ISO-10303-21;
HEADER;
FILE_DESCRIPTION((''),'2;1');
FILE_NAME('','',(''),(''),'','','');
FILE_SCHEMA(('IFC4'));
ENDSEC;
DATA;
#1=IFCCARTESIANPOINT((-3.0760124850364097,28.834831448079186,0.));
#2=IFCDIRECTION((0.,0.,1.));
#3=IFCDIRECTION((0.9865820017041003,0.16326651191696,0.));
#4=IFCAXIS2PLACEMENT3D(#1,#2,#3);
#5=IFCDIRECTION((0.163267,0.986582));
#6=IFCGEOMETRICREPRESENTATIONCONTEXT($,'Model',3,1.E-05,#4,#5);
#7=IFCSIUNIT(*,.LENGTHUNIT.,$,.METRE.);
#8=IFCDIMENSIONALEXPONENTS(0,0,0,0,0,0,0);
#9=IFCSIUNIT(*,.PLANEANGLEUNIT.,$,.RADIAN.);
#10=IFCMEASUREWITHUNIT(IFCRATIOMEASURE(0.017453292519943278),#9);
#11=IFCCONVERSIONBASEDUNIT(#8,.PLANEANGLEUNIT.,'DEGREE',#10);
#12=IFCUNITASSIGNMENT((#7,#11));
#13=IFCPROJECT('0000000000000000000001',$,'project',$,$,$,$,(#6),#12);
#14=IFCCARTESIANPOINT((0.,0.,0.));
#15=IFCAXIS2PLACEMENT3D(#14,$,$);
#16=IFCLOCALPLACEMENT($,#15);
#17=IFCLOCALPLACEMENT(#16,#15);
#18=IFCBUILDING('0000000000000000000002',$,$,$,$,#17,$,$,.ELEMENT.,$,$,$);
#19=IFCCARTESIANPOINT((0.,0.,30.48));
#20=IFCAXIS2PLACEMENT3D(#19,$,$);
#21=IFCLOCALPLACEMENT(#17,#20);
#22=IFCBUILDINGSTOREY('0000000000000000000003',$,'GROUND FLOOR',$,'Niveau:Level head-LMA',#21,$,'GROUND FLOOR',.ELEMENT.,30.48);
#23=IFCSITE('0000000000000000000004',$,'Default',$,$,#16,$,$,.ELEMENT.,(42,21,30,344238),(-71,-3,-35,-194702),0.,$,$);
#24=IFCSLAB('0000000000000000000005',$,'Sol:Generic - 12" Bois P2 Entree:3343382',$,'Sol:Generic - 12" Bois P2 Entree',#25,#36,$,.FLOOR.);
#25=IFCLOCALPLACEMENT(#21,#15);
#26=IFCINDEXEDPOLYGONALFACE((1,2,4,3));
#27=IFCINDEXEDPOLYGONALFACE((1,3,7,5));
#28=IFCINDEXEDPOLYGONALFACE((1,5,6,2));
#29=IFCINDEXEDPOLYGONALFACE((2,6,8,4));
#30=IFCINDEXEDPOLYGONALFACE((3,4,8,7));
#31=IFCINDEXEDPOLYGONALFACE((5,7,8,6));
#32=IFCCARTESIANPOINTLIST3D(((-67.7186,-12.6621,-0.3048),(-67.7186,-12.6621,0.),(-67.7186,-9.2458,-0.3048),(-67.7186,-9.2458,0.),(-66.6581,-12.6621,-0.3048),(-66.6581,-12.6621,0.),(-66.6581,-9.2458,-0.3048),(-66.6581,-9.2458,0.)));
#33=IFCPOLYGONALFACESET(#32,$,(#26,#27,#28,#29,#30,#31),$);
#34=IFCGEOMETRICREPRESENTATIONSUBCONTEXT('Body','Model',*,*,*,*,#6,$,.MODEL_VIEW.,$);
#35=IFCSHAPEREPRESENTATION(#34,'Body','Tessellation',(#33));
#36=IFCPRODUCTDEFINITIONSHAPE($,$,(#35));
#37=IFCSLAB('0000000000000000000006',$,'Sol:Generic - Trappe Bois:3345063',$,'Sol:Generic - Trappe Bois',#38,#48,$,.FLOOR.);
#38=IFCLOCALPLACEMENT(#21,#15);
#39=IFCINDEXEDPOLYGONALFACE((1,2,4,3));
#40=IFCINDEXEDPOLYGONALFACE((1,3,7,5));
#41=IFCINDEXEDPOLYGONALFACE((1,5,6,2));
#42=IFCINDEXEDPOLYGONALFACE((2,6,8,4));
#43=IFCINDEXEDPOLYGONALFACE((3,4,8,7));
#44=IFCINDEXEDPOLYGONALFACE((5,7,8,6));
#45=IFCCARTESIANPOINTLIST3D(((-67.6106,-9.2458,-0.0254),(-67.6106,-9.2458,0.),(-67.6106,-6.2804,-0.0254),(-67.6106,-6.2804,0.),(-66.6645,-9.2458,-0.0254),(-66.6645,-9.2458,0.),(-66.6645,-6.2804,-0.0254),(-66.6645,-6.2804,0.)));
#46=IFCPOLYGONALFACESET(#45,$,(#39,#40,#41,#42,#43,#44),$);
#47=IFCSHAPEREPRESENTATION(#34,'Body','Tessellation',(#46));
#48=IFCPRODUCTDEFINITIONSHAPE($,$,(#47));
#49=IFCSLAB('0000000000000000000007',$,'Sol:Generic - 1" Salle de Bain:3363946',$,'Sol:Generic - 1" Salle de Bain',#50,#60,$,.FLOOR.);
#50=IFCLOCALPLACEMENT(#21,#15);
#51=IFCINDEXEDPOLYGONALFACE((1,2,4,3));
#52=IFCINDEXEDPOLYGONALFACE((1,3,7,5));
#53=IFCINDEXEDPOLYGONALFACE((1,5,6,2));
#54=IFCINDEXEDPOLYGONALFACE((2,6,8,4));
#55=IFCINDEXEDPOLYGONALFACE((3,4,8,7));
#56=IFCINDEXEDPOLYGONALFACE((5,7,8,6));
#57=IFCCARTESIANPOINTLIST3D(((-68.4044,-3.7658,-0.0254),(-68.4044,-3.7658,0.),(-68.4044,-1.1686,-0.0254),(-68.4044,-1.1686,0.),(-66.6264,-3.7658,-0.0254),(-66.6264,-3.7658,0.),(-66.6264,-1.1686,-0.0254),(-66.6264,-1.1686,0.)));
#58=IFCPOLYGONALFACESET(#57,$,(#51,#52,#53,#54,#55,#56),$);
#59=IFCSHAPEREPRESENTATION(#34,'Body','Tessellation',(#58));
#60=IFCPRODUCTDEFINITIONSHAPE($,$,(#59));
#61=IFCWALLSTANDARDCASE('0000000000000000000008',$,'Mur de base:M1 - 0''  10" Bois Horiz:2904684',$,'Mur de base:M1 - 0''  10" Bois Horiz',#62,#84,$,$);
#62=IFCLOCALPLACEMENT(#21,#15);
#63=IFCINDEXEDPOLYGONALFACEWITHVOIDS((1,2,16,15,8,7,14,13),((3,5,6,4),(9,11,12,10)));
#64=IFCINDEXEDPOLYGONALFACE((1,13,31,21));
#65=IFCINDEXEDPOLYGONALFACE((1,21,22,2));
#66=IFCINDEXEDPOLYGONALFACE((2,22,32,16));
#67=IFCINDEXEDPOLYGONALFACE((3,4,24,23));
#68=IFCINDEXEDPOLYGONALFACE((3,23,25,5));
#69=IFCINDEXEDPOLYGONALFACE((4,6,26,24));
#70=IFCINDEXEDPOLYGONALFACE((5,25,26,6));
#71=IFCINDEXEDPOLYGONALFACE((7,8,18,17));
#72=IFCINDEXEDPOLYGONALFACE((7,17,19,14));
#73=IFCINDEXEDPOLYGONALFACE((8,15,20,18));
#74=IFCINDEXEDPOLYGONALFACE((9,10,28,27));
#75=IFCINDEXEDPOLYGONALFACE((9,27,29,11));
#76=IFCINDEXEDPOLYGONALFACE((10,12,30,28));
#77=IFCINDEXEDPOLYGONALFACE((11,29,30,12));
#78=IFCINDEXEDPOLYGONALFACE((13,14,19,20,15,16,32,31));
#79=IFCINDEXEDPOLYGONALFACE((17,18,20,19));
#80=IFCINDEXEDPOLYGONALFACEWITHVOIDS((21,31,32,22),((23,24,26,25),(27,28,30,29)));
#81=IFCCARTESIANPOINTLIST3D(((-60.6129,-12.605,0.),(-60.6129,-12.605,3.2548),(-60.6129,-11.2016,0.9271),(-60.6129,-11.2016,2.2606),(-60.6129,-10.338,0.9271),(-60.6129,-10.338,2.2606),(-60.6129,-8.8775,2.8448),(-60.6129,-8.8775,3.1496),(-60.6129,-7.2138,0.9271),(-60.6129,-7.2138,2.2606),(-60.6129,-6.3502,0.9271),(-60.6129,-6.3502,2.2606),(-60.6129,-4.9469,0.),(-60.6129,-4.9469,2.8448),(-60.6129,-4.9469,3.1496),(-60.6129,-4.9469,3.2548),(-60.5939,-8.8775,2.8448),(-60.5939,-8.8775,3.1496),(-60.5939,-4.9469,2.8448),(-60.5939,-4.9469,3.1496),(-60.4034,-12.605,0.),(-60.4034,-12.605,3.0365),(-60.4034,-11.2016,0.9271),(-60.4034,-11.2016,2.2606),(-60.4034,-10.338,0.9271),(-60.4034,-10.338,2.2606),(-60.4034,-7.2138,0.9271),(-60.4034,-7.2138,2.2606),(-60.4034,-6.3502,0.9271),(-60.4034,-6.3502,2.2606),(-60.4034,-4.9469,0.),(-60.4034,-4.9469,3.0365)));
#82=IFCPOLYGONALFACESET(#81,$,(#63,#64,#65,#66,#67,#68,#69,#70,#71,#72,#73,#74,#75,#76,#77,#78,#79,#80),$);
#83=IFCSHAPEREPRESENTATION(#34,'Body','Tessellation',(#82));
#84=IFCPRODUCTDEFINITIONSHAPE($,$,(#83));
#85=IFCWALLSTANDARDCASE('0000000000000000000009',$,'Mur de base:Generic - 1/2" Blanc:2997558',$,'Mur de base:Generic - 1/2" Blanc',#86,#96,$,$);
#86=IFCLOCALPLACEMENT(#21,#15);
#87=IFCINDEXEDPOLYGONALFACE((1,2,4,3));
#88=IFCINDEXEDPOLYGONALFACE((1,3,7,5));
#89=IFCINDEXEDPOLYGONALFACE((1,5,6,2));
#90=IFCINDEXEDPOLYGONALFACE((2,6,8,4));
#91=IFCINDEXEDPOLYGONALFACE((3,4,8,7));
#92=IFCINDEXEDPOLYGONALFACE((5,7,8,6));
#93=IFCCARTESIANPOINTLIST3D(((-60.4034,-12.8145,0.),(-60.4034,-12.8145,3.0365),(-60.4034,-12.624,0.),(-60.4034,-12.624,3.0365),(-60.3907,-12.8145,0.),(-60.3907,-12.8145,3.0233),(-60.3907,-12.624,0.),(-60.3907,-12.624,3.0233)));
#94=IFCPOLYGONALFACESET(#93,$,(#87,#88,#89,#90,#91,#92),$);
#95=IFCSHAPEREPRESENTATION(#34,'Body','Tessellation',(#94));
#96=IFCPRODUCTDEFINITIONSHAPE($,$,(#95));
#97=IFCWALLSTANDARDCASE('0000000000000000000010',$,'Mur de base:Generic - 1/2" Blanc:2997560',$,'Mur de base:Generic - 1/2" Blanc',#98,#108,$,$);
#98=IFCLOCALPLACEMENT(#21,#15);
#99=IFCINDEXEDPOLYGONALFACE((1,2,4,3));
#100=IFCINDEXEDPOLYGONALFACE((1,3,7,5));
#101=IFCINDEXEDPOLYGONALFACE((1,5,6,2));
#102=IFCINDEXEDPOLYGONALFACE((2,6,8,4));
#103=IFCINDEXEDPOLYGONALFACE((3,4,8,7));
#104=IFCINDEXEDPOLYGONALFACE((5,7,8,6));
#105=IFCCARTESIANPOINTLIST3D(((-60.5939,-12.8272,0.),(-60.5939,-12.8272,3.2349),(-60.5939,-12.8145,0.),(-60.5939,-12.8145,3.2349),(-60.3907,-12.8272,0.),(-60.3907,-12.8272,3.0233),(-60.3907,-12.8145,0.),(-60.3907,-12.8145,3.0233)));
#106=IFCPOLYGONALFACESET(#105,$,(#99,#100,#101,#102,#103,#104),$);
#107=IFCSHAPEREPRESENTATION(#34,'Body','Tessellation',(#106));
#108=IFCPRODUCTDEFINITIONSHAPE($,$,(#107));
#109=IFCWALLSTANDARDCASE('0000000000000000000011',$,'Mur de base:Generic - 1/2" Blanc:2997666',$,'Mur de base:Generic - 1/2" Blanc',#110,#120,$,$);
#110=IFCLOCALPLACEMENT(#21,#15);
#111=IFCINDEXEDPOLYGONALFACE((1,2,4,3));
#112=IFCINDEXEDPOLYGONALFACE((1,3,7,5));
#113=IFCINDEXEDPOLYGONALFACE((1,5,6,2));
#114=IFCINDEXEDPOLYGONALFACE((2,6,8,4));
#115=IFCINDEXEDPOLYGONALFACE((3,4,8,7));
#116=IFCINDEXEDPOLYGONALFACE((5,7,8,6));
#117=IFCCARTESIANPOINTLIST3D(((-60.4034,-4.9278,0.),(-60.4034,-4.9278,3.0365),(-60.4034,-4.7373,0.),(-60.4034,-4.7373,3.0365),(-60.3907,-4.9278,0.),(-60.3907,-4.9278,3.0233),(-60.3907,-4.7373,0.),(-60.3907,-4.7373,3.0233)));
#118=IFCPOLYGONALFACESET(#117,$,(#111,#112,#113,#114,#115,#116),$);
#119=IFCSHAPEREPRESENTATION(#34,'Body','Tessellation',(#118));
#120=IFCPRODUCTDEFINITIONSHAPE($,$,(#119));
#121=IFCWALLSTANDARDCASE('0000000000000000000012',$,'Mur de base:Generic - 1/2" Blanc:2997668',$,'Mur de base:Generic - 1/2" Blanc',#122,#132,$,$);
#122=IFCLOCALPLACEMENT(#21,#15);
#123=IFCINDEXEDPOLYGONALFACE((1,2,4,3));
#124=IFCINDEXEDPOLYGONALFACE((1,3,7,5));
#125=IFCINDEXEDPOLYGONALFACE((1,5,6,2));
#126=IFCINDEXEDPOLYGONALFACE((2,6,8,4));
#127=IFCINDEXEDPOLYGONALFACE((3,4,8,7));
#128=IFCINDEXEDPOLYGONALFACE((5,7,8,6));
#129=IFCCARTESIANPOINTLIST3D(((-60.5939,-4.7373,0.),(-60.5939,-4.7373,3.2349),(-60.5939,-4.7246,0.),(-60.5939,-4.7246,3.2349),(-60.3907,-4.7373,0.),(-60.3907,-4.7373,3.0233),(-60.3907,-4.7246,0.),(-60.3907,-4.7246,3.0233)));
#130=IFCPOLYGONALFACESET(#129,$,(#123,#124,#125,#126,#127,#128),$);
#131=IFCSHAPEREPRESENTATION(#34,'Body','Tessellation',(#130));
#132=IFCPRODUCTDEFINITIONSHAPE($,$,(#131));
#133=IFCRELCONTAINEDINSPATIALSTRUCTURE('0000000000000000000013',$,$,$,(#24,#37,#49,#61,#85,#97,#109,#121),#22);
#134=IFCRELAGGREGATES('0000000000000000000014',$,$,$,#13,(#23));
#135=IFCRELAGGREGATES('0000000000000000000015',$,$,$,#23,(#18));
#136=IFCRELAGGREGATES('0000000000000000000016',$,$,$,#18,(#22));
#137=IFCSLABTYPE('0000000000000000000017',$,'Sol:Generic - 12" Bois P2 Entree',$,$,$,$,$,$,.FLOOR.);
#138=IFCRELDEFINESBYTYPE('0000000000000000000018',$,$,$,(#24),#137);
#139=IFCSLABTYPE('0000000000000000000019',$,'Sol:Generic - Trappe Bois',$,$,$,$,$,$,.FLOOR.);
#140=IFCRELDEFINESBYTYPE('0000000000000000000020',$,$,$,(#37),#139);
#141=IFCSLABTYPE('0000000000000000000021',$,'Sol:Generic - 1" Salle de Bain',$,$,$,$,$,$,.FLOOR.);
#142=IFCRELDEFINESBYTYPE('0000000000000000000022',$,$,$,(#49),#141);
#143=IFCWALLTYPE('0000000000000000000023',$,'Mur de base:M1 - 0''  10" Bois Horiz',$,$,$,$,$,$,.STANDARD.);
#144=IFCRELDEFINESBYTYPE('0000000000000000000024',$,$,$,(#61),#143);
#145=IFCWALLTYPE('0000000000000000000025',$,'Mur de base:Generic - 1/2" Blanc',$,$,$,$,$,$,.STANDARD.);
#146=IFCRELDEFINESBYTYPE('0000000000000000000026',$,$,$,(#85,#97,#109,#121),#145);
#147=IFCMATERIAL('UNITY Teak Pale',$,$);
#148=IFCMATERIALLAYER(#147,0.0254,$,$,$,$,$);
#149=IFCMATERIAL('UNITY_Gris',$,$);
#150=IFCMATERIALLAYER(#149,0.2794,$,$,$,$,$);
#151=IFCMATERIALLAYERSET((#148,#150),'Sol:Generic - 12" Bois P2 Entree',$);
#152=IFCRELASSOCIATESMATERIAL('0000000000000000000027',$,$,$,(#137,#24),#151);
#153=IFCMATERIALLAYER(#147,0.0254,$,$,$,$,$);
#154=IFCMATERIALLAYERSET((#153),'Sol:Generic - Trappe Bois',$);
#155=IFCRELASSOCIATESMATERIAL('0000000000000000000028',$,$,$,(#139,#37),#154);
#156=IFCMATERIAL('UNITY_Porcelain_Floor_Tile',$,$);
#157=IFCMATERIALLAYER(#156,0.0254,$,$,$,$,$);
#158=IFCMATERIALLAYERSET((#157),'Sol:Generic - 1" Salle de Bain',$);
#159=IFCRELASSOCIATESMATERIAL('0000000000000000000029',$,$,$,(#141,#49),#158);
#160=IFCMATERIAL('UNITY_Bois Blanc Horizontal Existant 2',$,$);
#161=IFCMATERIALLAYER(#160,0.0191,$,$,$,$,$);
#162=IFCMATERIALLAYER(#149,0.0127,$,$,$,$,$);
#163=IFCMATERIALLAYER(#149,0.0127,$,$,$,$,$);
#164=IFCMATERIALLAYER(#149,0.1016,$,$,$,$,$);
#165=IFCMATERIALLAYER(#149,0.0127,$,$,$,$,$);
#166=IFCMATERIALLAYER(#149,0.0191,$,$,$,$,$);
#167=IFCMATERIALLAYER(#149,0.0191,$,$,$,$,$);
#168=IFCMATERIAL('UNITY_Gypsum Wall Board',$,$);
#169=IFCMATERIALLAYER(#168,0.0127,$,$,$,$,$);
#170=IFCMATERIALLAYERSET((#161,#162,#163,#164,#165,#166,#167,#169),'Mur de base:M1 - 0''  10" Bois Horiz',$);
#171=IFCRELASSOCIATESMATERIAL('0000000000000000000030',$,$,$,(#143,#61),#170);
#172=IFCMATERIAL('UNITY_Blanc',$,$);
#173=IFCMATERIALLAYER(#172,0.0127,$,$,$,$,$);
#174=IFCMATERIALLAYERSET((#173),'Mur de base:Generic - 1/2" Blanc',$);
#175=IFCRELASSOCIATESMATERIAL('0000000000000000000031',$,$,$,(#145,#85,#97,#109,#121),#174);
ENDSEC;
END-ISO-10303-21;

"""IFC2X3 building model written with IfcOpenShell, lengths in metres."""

from ifc_helpers import new_model, entity, si_unit, converted_unit, direction, frame, frame_2d, origin, place, context, subcontext, project, spatial, polyline, rectangle, extrude, clip, bounded_halfspace, material, layer, layer_set, layer_usage, type_object, element, save


model = new_model("IFC2X3")

# Units and contexts
model_context = context("Model", 3, precision=1e-05, world=frame((-3.0760124850364097, 28.834831448079186, 0.0), z_axis=(0.0, 0.0, 1.0), x_axis=(0.9865820017041003, 0.16326651191696, 0.0)), true_north=direction((0.163267, 0.986582)))
body_context = subcontext(model_context, "Body", "Model", "MODEL_VIEW")
ifc_project = project(units=[si_unit("LENGTHUNIT", "METRE"), converted_unit("PLANEANGLEUNIT", "DEGREE", entity("IfcRatioMeasure", 0.017453292519943278), si_unit("PLANEANGLEUNIT", "RADIAN"), dimensions=[0, 0, 0, 0, 0, 0, 0])], contexts=[model_context])

# Site, building, storey
site_placement = place(None, origin())
site = spatial("IfcSite", under=ifc_project, at=site_placement, Name="Default", CompositionType="ELEMENT", RefLatitude=(42, 21, 30, 344238), RefLongitude=(-71, -3, -35, -194702), RefElevation=0.0)
building_placement = place(site_placement, origin())
building = spatial("IfcBuilding", under=site, at=building_placement, CompositionType="ELEMENT")
storey_placement = place(building_placement, frame((0.0, 0.0, 30.48)))
storey = spatial("IfcBuildingStorey", under=building, at=storey_placement, Name="GROUND FLOOR", ObjectType="Niveau:Level head-LMA", LongName="GROUND FLOOR", CompositionType="ELEMENT", Elevation=30.48)

# Slabs
ifc_material_1 = material(Name="UNITY_Gris")
ifc_material_2 = material(Name="UNITY Teak Pale")
ifc_layer_1 = layer(ifc_material_2, 0.0254)
ifc_layer_2 = layer(ifc_material_1, 0.2794)
ifc_layer_set_1 = layer_set([ifc_layer_1, ifc_layer_2], Name="Sol:Generic - 12\" Bois P2 Entree")
ifc_layer_usage_1 = layer_usage(ifc_layer_set_1, "AXIS3", "POSITIVE", 0.0)
slab_type_1 = type_object("IfcSlabType", Name="Sol:Generic - 12\" Bois P2 Entree", PredefinedType="FLOOR", material=ifc_layer_set_1)
slab_1_placement = place(storey_placement, origin())
element("IfcSlab", 1, at=slab_1_placement, inside=storey, type_object=slab_type_1, material=ifc_layer_usage_1, Name="Sol:Generic - 12\" Bois P2 Entree:3343382", ObjectType="Sol:Generic - 12\" Bois P2 Entree", PredefinedType="FLOOR", context=body_context, shape_type="SweptSolid", body=[
    extrude(rectangle(XDim=3.4163, YDim=1.0605, at=frame_2d((0.0, 0.0), x_axis=(1.0, 0.0))), frame((-67.1884, -10.954, 0.0), z_axis=(0.0, 0.0, -1.0), x_axis=(0.0, 1.0, 0.0)), (0.0, 0.0, 1.0), 0.3048),
])
ifc_layer_3 = layer(ifc_material_2, 0.0254)
ifc_layer_set_2 = layer_set([ifc_layer_3], Name="Sol:Generic - Trappe Bois")
ifc_layer_usage_2 = layer_usage(ifc_layer_set_2, "AXIS3", "POSITIVE", 0.0)
slab_type_2 = type_object("IfcSlabType", Name="Sol:Generic - Trappe Bois", PredefinedType="FLOOR", material=ifc_layer_set_2)
slab_2_placement = place(storey_placement, origin())
element("IfcSlab", 2, at=slab_2_placement, inside=storey, type_object=slab_type_2, material=ifc_layer_usage_2, Name="Sol:Generic - Trappe Bois:3345063", ObjectType="Sol:Generic - Trappe Bois", PredefinedType="FLOOR", context=body_context, shape_type="SweptSolid", body=[
    extrude(rectangle(XDim=2.9654, YDim=0.9462, at=frame_2d((0.0, 0.0), x_axis=(1.0, 0.0))), frame((-67.1376, -7.7631, 0.0), z_axis=(0.0, 0.0, -1.0), x_axis=(0.0, 1.0, 0.0)), (0.0, 0.0, 1.0), 0.0254),
])
ifc_material_3 = material(Name="UNITY_Porcelain_Floor_Tile")
ifc_layer_4 = layer(ifc_material_3, 0.0254)
ifc_layer_set_3 = layer_set([ifc_layer_4], Name="Sol:Generic - 1\" Salle de Bain")
ifc_layer_usage_3 = layer_usage(ifc_layer_set_3, "AXIS3", "POSITIVE", 0.0)
slab_type_3 = type_object("IfcSlabType", Name="Sol:Generic - 1\" Salle de Bain", PredefinedType="FLOOR", material=ifc_layer_set_3)
slab_3_placement = place(storey_placement, origin())
element("IfcSlab", 3, at=slab_3_placement, inside=storey, type_object=slab_type_3, material=ifc_layer_usage_3, Name="Sol:Generic - 1\" Salle de Bain:3363946", ObjectType="Sol:Generic - 1\" Salle de Bain", PredefinedType="FLOOR", context=body_context, shape_type="SweptSolid", body=[
    extrude(rectangle(XDim=2.5971, YDim=1.778, at=frame_2d((0.0, 0.0), x_axis=(1.0, 0.0))), frame((-67.5154, -2.4672, 0.0), z_axis=(0.0, 0.0, -1.0), x_axis=(0.0, 1.0, 0.0)), (0.0, 0.0, 1.0), 0.0254),
])

# Wall, openings
ifc_material_4 = material(Name="UNITY_Bois Blanc Horizontal Existant 2")
ifc_layer_5 = layer(ifc_material_4, 0.0191)
ifc_layer_6 = layer(ifc_material_1, 0.0127)
ifc_layer_7 = layer(ifc_material_1, 0.0127)
ifc_layer_8 = layer(ifc_material_1, 0.1016)
ifc_layer_9 = layer(ifc_material_1, 0.0127)
ifc_layer_10 = layer(ifc_material_1, 0.0191)
ifc_layer_11 = layer(ifc_material_1, 0.0191)
ifc_material_5 = material(Name="UNITY_Gypsum Wall Board")
ifc_layer_12 = layer(ifc_material_5, 0.0127)
ifc_layer_set_4 = layer_set([ifc_layer_5, ifc_layer_6, ifc_layer_7, ifc_layer_8, ifc_layer_9, ifc_layer_10, ifc_layer_11, ifc_layer_12], Name="Mur de base:M1 - 0'  10\" Bois Horiz")
ifc_layer_usage_4 = layer_usage(ifc_layer_set_4, "AXIS2", "NEGATIVE", 0.1048)
wall_type_1 = type_object("IfcWallType", Name="Mur de base:M1 - 0'  10\" Bois Horiz", PredefinedType="STANDARD", material=ifc_layer_set_4)
wall_1_placement = place(storey_placement, frame((-60.5082, -4.9469, 0.0), z_axis=(0.0, 0.0, 1.0), x_axis=(0.0, -1.0, 0.0)))
wall_1 = element("IfcWallStandardCase", 4, at=wall_1_placement, inside=storey, type_object=wall_type_1, material=ifc_layer_usage_4, Name="Mur de base:M1 - 0'  10\" Bois Horiz:2904684", ObjectType="Mur de base:M1 - 0'  10\" Bois Horiz", context=body_context, shape_type="Clipping", body=[
    clip(extrude(rectangle(XDim=7.6581, YDim=0.2096, at=frame_2d((3.8291, 0.0), x_axis=(-1.0, 0.0))), origin(), (0.0, 0.0, 1.0), 3.2548), bounded_halfspace(frame((0.0, -0.1048, 3.2548), z_axis=(0.0, 0.721387, 0.692532), x_axis=(-1.0, 0.0, 0.0)), False, frame((0.0, -0.1048, 3.2548)), polyline([(0.0, 0.0), (7.6581, 0.0), (7.6581, 0.2095), (0.0, 0.2096), (0.0, 0.0)]))),
])
opening_1_placement = place(storey_placement, frame((-60.5082, -4.9469, 0.0), z_axis=(0.0, 0.0, 1.0), x_axis=(0.0, -1.0, 0.0)))
element("IfcOpeningElement", 5, at=opening_1_placement, cuts=wall_1, ObjectType="Opening", context=body_context, shape_type="SweptSolid", body=[
    extrude(rectangle(XDim=0.019, YDim=3.9306, at=frame_2d((0.0, 0.0), x_axis=(1.0, 0.0))), frame((1.9653, -0.0953, 2.8448), z_axis=(0.0, 0.0, 1.0), x_axis=(0.0, 1.0, 0.0)), (0.0, 0.0, 1.0), 0.3048),
])
opening_2_placement = place(wall_1_placement, frame((-4.9469, 60.5082, 0.0), z_axis=(0.0, 0.0, 1.0), x_axis=(0.0, 1.0, 0.0)))
element("IfcOpeningElement", 6, at=opening_2_placement, cuts=wall_1, ObjectType="Opening", context=body_context, shape_type="SweptSolid", body=[
    extrude(rectangle(XDim=1.3335, YDim=0.8636, at=frame_2d((0.0, 0.0), x_axis=(1.0, 0.0))), frame((-62.1369, -6.782, 1.5938), z_axis=(1.0, 0.0, 0.0), x_axis=(0.0, 0.0, 1.0)), (0.0, 0.0, 1.0), 3.048),
])
opening_3_placement = place(wall_1_placement, frame((-4.9469, 60.5082, 0.0), z_axis=(0.0, 0.0, 1.0), x_axis=(0.0, 1.0, 0.0)))
element("IfcOpeningElement", 7, at=opening_3_placement, cuts=wall_1, ObjectType="Opening", context=body_context, shape_type="SweptSolid", body=[
    extrude(rectangle(XDim=1.3335, YDim=0.8636, at=frame_2d((0.0, 0.0), x_axis=(1.0, 0.0))), frame((-62.1369, -10.7698, 1.5938), z_axis=(1.0, 0.0, 0.0), x_axis=(0.0, 0.0, 1.0)), (0.0, 0.0, 1.0), 3.048),
])

# Walls
ifc_material_6 = material(Name="UNITY_Blanc")
ifc_layer_13 = layer(ifc_material_6, 0.0127)
ifc_layer_set_5 = layer_set([ifc_layer_13], Name="Mur de base:Generic - 1/2\" Blanc")
ifc_layer_usage_5 = layer_usage(ifc_layer_set_5, "AXIS2", "NEGATIVE", 0.0063)
wall_type_2 = type_object("IfcWallType", Name="Mur de base:Generic - 1/2\" Blanc", PredefinedType="STANDARD", material=ifc_layer_set_5)
wall_2_placement = place(storey_placement, frame((-60.397, -12.624, 0.0), z_axis=(0.0, 0.0, 1.0), x_axis=(0.0, -1.0, 0.0)))
element("IfcWallStandardCase", 8, at=wall_2_placement, inside=storey, type_object=wall_type_2, material=ifc_layer_usage_5, Name="Mur de base:Generic - 1/2\" Blanc:2997558", ObjectType="Mur de base:Generic - 1/2\" Blanc", context=body_context, shape_type="Clipping", body=[
    clip(extrude(rectangle(XDim=0.1905, YDim=0.0127, at=frame_2d((0.0952, 0.0), x_axis=(-1.0, 0.0))), origin(), (0.0, 0.0, 1.0), 3.0365), bounded_halfspace(frame((0.0, -0.0063, 3.0365), z_axis=(0.0, 0.721387, 0.692532), x_axis=(-1.0, 0.0, 0.0)), False, frame((0.0, -0.0063, 3.0365)), polyline([(0.0, 0.0), (0.1905, 0.0), (0.1905, 0.0127), (0.0, 0.0127), (0.0, 0.0)]))),
])
ifc_layer_usage_6 = layer_usage(ifc_layer_set_5, "AXIS2", "NEGATIVE", 0.0063)
wall_3_placement = place(storey_placement, frame((-60.3907, -12.8209, 0.0), z_axis=(0.0, 0.0, 1.0), x_axis=(-1.0, 0.0, 0.0)))
element("IfcWallStandardCase", 9, at=wall_3_placement, inside=storey, type_object=wall_type_2, material=ifc_layer_usage_6, Name="Mur de base:Generic - 1/2\" Blanc:2997560", ObjectType="Mur de base:Generic - 1/2\" Blanc", context=body_context, shape_type="Clipping", body=[
    clip(extrude(rectangle(XDim=0.2032, YDim=0.0127, at=frame_2d((0.1016, 0.0), x_axis=(-1.0, 0.0))), origin(), (0.0, 0.0, 1.0), 3.2349), bounded_halfspace(frame((0.0, -0.0063, 3.0233), z_axis=(-0.721387, 0.0, 0.692532), x_axis=(0.0, -1.0, 0.0)), False, frame((0.0, -0.0063, 3.0233)), polyline([(0.0, 0.0), (0.0127, 0.0), (0.2032, 0.0), (0.2032, 0.0127), (0.0, 0.0127), (0.0, 0.0)]))),
])
ifc_layer_usage_7 = layer_usage(ifc_layer_set_5, "AXIS2", "POSITIVE", -0.0063)
wall_4_placement = place(storey_placement, frame((-60.397, -4.9278, 0.0), z_axis=(0.0, 0.0, 1.0), x_axis=(0.0, 1.0, 0.0)))
element("IfcWallStandardCase", 10, at=wall_4_placement, inside=storey, type_object=wall_type_2, material=ifc_layer_usage_7, Name="Mur de base:Generic - 1/2\" Blanc:2997666", ObjectType="Mur de base:Generic - 1/2\" Blanc", context=body_context, shape_type="Clipping", body=[
    clip(extrude(rectangle(XDim=0.1905, YDim=0.0127, at=frame_2d((0.0952, 0.0), x_axis=(-1.0, 0.0))), origin(), (0.0, 0.0, 1.0), 3.0365), bounded_halfspace(frame((0.0, -0.0063, 3.0233), z_axis=(0.0, -0.721387, 0.692532), x_axis=(1.0, 0.0, 0.0)), False, frame((0.0, -0.0063, 3.0233)), polyline([(0.0, 0.0), (0.1905, 0.0), (0.1905, 0.0127), (0.0, 0.0127), (0.0, 0.0)]))),
])
ifc_layer_usage_8 = layer_usage(ifc_layer_set_5, "AXIS2", "POSITIVE", -0.0063)
wall_5_placement = place(storey_placement, frame((-60.3907, -4.731, 0.0), z_axis=(0.0, 0.0, 1.0), x_axis=(-1.0, 0.0, 0.0)))
element("IfcWallStandardCase", 11, at=wall_5_placement, inside=storey, type_object=wall_type_2, material=ifc_layer_usage_8, Name="Mur de base:Generic - 1/2\" Blanc:2997668", ObjectType="Mur de base:Generic - 1/2\" Blanc", context=body_context, shape_type="Clipping", body=[
    clip(extrude(rectangle(XDim=0.2032, YDim=0.0127, at=frame_2d((0.1016, 0.0), x_axis=(-1.0, 0.0))), origin(), (0.0, 0.0, 1.0), 3.2349), bounded_halfspace(frame((0.0, -0.0063, 3.0233), z_axis=(-0.721387, 0.0, 0.692532), x_axis=(0.0, -1.0, 0.0)), False, frame((0.0, -0.0063, 3.0233)), polyline([(0.0, 0.0), (0.2032, 0.0), (0.2032, 0.0127), (0.0127, 0.0127), (0.0, 0.0127), (0.0, 0.0)]))),
])

save(model, "model.ifc")
